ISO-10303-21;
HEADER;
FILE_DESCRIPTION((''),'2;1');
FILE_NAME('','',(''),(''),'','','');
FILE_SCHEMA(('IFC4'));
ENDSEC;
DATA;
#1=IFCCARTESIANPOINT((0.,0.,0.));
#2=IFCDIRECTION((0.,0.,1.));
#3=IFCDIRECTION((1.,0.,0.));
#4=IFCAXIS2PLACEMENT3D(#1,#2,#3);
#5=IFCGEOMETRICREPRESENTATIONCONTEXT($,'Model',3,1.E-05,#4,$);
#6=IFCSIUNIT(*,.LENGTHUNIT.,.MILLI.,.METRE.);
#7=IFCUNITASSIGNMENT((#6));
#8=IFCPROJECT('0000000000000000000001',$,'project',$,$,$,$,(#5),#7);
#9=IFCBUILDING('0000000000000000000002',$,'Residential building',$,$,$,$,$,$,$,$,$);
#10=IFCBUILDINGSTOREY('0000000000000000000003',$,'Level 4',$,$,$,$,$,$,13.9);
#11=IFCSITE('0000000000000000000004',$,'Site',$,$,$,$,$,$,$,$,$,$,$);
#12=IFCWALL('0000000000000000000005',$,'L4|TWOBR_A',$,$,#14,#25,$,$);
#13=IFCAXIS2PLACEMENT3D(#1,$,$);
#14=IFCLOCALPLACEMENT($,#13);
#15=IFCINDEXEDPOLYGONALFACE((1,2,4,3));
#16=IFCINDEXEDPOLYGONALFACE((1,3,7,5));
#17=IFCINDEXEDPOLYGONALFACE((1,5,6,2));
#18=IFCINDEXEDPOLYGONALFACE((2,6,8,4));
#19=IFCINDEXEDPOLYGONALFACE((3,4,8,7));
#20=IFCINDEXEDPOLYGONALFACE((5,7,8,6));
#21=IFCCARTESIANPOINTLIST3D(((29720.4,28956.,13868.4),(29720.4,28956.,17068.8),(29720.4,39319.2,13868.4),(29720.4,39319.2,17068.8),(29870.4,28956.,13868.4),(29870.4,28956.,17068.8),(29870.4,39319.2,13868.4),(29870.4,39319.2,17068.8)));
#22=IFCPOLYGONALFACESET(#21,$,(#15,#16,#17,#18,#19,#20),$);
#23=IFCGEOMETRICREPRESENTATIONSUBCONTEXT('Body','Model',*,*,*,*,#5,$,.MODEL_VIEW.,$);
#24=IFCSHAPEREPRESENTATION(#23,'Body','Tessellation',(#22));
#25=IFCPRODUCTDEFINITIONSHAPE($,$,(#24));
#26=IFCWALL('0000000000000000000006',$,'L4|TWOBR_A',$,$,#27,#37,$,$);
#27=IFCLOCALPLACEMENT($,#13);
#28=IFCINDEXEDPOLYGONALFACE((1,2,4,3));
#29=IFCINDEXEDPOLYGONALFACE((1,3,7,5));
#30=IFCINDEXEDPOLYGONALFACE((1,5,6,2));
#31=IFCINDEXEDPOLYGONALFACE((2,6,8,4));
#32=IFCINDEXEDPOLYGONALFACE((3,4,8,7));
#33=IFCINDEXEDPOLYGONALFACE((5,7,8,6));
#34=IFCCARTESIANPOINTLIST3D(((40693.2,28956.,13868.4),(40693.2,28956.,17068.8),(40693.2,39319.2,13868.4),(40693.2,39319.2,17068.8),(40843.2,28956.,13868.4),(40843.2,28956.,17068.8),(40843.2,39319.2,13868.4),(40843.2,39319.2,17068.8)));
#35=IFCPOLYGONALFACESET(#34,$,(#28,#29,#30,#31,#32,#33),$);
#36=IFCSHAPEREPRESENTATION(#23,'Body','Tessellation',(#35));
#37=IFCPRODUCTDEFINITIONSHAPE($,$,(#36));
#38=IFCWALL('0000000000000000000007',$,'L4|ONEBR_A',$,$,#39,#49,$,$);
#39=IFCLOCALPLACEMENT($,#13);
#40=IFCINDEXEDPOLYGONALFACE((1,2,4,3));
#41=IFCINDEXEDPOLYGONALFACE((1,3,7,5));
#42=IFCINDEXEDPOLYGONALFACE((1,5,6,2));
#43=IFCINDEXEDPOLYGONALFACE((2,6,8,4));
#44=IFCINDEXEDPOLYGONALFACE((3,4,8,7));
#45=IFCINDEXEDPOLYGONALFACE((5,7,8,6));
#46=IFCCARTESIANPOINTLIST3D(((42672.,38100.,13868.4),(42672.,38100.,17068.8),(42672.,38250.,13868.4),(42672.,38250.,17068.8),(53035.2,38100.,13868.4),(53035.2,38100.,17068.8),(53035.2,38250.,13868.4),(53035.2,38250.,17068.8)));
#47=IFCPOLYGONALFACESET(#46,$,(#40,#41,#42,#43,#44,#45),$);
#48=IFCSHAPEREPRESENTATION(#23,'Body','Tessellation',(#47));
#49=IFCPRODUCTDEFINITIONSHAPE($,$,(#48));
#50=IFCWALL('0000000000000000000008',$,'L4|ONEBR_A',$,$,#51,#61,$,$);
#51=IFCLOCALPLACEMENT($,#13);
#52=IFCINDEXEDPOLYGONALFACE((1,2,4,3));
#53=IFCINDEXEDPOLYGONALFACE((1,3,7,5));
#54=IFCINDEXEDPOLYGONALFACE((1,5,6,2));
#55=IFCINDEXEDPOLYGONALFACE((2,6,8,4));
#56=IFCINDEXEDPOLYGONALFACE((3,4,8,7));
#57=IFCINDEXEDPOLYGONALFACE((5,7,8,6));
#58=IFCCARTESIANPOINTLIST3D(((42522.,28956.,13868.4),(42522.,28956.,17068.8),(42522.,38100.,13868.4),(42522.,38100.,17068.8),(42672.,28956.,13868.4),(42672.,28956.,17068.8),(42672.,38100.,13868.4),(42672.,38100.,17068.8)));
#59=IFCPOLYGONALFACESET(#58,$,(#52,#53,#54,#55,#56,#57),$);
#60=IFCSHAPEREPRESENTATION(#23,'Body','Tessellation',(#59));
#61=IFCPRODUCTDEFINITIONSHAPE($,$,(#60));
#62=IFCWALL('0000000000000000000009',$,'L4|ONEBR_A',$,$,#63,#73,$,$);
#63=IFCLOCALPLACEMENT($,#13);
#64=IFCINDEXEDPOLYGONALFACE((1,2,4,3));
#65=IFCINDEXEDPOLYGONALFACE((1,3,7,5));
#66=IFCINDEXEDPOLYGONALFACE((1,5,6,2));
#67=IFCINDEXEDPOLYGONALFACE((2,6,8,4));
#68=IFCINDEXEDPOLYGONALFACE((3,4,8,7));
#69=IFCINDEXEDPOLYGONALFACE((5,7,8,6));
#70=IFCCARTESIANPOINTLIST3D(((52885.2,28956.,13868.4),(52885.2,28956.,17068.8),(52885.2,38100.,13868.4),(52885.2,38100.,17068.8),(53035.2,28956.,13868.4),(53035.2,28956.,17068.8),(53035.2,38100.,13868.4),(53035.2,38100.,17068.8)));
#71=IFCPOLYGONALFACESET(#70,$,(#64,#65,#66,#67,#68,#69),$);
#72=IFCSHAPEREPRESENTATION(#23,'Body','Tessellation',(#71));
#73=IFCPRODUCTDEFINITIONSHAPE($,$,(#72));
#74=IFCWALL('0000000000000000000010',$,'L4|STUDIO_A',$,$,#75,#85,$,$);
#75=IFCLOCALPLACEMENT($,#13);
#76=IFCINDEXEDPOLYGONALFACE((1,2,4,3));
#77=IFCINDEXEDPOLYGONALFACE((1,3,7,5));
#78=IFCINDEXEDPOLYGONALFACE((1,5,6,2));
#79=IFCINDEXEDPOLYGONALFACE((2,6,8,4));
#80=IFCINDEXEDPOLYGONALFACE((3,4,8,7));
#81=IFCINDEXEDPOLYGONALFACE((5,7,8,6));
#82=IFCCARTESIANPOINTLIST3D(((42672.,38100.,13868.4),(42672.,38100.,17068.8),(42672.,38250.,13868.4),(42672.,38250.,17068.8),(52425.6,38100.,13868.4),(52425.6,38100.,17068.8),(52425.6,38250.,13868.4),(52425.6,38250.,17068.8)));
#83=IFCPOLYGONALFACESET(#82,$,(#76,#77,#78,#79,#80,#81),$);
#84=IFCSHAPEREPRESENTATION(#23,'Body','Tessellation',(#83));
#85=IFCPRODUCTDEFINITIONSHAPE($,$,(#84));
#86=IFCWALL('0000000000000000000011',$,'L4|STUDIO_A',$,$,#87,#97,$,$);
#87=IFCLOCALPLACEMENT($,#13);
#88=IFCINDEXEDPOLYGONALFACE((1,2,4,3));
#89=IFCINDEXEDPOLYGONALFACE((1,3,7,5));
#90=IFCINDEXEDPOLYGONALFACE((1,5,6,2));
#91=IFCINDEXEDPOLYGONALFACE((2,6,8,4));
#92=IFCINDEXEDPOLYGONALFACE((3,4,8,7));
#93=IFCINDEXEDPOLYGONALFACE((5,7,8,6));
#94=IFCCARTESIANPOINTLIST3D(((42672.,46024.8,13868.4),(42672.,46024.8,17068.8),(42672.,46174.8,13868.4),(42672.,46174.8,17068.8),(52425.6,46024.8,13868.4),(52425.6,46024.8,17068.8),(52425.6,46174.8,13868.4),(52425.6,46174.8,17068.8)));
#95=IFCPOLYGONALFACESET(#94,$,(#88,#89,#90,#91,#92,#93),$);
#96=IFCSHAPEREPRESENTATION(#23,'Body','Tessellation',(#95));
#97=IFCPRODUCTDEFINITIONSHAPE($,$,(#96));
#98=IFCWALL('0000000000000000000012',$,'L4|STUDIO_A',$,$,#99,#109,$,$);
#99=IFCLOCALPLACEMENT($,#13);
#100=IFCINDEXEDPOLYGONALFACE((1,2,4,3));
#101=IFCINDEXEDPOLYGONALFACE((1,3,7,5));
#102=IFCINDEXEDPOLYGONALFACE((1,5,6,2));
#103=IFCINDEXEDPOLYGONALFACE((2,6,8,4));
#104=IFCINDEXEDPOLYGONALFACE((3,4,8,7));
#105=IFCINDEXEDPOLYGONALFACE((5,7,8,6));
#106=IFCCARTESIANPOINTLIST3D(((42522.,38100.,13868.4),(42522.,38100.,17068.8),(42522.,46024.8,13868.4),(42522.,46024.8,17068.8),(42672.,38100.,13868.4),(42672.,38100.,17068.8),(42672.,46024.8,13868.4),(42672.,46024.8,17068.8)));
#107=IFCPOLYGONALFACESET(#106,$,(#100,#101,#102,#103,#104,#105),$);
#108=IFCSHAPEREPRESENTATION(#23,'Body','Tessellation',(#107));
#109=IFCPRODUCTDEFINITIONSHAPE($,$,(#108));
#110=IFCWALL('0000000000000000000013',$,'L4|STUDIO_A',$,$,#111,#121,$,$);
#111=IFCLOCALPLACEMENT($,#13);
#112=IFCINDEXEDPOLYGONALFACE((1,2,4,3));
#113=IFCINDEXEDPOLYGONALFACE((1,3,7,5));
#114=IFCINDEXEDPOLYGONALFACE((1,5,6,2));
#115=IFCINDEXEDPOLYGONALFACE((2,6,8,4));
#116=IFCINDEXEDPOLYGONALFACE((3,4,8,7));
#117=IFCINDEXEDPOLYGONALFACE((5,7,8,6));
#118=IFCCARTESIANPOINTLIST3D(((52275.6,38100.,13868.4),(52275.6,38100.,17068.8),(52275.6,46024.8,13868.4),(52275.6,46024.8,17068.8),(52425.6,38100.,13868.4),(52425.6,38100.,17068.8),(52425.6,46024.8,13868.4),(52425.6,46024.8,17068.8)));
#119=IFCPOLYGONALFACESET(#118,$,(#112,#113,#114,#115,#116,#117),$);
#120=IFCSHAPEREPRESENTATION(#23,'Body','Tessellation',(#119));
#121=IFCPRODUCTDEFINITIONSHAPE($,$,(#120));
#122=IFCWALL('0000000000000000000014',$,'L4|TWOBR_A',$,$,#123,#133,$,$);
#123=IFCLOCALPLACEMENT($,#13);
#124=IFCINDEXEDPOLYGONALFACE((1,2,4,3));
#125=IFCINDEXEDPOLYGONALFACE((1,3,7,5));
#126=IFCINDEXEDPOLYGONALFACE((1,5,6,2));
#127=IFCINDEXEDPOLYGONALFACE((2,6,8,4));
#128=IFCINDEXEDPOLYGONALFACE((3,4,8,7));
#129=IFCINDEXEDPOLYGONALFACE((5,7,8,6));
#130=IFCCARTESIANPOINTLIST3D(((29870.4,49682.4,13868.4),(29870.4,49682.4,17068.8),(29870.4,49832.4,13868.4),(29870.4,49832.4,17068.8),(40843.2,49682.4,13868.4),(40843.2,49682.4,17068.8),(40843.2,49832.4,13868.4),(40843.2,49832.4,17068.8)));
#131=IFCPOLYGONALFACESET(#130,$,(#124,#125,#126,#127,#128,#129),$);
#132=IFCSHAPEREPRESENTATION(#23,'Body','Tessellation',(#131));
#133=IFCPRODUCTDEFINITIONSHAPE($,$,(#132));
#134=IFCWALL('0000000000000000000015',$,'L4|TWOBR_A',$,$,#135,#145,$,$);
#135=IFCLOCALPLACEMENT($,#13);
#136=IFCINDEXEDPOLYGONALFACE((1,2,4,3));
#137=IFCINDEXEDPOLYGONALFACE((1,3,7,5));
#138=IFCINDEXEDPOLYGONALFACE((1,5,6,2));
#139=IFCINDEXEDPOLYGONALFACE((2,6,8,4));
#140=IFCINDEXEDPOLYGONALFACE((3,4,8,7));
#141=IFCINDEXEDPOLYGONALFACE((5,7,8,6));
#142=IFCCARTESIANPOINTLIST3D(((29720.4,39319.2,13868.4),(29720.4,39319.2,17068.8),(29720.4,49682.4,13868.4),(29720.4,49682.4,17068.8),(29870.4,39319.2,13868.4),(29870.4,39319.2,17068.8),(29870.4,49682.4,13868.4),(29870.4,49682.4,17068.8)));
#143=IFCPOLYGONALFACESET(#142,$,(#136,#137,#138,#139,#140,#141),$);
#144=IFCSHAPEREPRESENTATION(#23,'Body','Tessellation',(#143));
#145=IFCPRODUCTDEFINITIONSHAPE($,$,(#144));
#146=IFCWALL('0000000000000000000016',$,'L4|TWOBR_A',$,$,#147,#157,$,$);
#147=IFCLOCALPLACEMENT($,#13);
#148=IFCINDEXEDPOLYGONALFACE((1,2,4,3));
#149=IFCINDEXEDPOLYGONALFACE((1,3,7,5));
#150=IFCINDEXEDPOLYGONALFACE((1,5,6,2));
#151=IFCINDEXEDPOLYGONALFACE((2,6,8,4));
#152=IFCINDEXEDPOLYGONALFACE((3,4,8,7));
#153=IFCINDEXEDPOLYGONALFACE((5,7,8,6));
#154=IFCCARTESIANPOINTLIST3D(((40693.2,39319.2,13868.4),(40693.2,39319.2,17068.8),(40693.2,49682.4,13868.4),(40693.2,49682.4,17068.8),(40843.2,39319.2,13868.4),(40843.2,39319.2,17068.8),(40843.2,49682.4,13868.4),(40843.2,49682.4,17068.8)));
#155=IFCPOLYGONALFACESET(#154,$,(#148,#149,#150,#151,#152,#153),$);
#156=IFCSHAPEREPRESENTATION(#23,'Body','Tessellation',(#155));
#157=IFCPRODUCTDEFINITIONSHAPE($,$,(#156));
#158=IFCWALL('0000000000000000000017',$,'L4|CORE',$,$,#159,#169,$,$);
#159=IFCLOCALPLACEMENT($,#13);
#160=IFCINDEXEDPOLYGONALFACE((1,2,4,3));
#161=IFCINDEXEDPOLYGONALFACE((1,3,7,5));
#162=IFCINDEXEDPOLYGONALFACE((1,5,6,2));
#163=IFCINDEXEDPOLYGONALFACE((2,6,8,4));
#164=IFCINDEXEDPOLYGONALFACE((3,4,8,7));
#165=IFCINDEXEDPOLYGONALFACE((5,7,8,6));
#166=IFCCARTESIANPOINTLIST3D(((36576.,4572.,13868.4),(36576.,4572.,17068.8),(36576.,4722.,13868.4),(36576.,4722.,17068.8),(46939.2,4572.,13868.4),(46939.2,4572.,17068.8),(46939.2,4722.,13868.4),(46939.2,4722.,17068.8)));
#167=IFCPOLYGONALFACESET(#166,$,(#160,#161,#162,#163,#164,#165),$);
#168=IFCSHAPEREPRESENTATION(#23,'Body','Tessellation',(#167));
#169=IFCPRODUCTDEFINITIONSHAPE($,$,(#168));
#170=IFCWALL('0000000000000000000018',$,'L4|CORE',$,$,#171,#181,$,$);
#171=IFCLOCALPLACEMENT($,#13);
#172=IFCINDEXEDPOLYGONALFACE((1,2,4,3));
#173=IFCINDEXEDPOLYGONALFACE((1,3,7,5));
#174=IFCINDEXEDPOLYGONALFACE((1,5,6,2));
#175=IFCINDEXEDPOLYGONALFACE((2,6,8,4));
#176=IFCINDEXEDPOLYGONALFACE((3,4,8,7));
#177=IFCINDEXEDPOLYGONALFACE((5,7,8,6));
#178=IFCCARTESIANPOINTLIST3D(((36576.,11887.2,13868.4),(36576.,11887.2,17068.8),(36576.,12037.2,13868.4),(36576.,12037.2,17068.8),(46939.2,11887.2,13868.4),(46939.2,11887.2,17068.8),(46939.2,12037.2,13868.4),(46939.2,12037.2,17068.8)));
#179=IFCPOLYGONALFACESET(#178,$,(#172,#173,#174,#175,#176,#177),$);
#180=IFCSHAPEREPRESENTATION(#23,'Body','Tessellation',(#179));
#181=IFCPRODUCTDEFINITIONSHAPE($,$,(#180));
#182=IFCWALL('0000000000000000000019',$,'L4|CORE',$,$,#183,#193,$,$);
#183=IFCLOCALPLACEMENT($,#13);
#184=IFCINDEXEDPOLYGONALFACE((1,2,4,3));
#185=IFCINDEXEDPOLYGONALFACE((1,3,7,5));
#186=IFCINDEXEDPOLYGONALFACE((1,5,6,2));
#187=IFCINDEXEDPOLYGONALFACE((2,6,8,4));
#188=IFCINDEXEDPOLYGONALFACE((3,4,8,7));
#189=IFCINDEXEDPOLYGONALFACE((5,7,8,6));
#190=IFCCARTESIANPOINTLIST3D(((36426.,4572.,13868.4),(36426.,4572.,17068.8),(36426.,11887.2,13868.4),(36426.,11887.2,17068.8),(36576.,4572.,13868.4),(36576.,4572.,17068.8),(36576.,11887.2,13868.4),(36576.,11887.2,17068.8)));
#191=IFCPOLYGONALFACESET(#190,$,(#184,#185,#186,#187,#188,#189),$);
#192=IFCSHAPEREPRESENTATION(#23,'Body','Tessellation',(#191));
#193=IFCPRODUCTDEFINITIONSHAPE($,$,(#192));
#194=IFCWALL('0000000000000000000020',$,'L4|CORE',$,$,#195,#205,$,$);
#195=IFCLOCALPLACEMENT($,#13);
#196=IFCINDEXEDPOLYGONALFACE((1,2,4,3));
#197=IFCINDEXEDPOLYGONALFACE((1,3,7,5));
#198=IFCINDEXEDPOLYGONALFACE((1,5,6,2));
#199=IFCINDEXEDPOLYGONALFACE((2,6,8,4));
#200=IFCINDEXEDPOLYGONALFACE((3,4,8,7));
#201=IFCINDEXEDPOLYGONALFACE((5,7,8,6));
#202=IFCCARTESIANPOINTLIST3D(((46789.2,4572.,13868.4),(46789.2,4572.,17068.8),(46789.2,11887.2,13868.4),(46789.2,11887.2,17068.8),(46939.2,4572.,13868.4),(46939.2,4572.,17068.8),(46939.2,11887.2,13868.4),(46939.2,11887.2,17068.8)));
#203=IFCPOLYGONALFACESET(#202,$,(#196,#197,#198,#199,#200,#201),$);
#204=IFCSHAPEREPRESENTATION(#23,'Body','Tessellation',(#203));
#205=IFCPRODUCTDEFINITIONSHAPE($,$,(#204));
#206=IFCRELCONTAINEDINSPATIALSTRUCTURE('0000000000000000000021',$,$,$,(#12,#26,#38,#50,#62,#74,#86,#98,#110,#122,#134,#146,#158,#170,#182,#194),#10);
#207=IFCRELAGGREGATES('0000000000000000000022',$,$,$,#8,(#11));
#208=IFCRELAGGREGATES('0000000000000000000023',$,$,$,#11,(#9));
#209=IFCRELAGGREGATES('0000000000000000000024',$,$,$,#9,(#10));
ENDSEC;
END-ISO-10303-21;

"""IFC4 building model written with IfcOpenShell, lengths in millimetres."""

from ifc_helpers import new_model, si_unit, frame, origin_with_axes, place, context, subcontext, project, spatial, indexed_curve, outline, extrude, element, save


model = new_model("IFC4")

# Units and contexts
model_context = context("Model", 3, precision=1e-05, world=origin_with_axes())
body_context = subcontext(model_context, "Body", "Model", "MODEL_VIEW")
ifc_project = project(units=[si_unit("LENGTHUNIT", "METRE", prefix="MILLI")], contexts=[model_context])

# Site, building, storey
site = spatial("IfcSite", under=ifc_project, Name="Site")
building = spatial("IfcBuilding", under=site, Name="Residential building")
storey = spatial("IfcBuildingStorey", under=building, Name="Level 4", Elevation=13.9)

# Walls
for number, where, z_axis, x_axis, name in (
    (1, (29870.4, 28956.0, 13868.4), (0.0, 0.0, 1.0), (0.0, 1.0, 0.0), "L4|TWOBR_A"),
    (2, (40843.2, 28956.0, 13868.4), (0.0, 0.0, 1.0), (0.0, 1.0, 0.0), "L4|TWOBR_A"),
    (3, (42672.0, 38100.0, 13868.4), (0.0, 0.0, 1.0), (1.0, 0.0, 0.0), "L4|ONEBR_A"),
):
    element("IfcWall", number, at=place(None, frame(where, z_axis=z_axis, x_axis=x_axis)), inside=storey, Name=name, context=body_context, shape_type="SweptSolid", body=[
        extrude(outline(indexed_curve([(0.0, 0.0), (0.0, 150.0), (10363.2, 150.0), (10363.2, 0.0), (0.0, 0.0)], self_intersect=False)), origin_with_axes(), (0.0, 0.0, 1.0), 3200.4),
    ])
for number, where, z_axis, x_axis, name in (
    (4, (42672.0, 28956.0, 13868.4), (0.0, 0.0, 1.0), (0.0, 1.0, 0.0), "L4|ONEBR_A"),
    (5, (53035.2, 28956.0, 13868.4), (0.0, 0.0, 1.0), (0.0, 1.0, 0.0), "L4|ONEBR_A"),
):
    element("IfcWall", number, at=place(None, frame(where, z_axis=z_axis, x_axis=x_axis)), inside=storey, Name=name, context=body_context, shape_type="SweptSolid", body=[
        extrude(outline(indexed_curve([(0.0, 0.0), (0.0, 150.0), (9144.0, 150.0), (9144.0, 0.0), (0.0, 0.0)], self_intersect=False)), origin_with_axes(), (0.0, 0.0, 1.0), 3200.4),
    ])
for number, where, z_axis, x_axis, name in (
    (6, (42672.0, 38100.0, 13868.4), (0.0, 0.0, 1.0), (1.0, 0.0, 0.0), "L4|STUDIO_A"),
    (7, (42672.0, 46024.8, 13868.4), (0.0, 0.0, 1.0), (1.0, 0.0, 0.0), "L4|STUDIO_A"),
):
    element("IfcWall", number, at=place(None, frame(where, z_axis=z_axis, x_axis=x_axis)), inside=storey, Name=name, context=body_context, shape_type="SweptSolid", body=[
        extrude(outline(indexed_curve([(0.0, 0.0), (0.0, 150.0), (9753.6, 150.0), (9753.6, 0.0), (0.0, 0.0)], self_intersect=False)), origin_with_axes(), (0.0, 0.0, 1.0), 3200.4),
    ])
for number, where, z_axis, x_axis, name in (
    (8, (42672.0, 38100.0, 13868.4), (0.0, 0.0, 1.0), (0.0, 1.0, 0.0), "L4|STUDIO_A"),
    (9, (52425.6, 38100.0, 13868.4), (0.0, 0.0, 1.0), (0.0, 1.0, 0.0), "L4|STUDIO_A"),
):
    element("IfcWall", number, at=place(None, frame(where, z_axis=z_axis, x_axis=x_axis)), inside=storey, Name=name, context=body_context, shape_type="SweptSolid", body=[
        extrude(outline(indexed_curve([(0.0, 0.0), (0.0, 150.0), (7924.8, 150.0), (7924.8, 0.0), (0.0, 0.0)], self_intersect=False)), origin_with_axes(), (0.0, 0.0, 1.0), 3200.4),
    ])
for number, where, z_axis, x_axis, name in (
    (10, (29870.4, 49682.4, 13868.4), (0.0, 0.0, 1.0), (1.0, 0.0, 0.0), "L4|TWOBR_A"),
):
    element("IfcWall", number, at=place(None, frame(where, z_axis=z_axis, x_axis=x_axis)), inside=storey, Name=name, context=body_context, shape_type="SweptSolid", body=[
        extrude(outline(indexed_curve([(0.0, 0.0), (0.0, 150.0), (10972.8, 150.0), (10972.8, 0.0), (0.0, 0.0)], self_intersect=False)), origin_with_axes(), (0.0, 0.0, 1.0), 3200.4),
    ])
for number, where, z_axis, x_axis, name in (
    (11, (29870.4, 39319.2, 13868.4), (0.0, 0.0, 1.0), (0.0, 1.0, 0.0), "L4|TWOBR_A"),
    (12, (40843.2, 39319.2, 13868.4), (0.0, 0.0, 1.0), (0.0, 1.0, 0.0), "L4|TWOBR_A"),
    (13, (36576.0, 4572.0, 13868.4), (0.0, 0.0, 1.0), (1.0, 0.0, 0.0), "L4|CORE"),
    (14, (36576.0, 11887.2, 13868.4), (0.0, 0.0, 1.0), (1.0, 0.0, 0.0), "L4|CORE"),
):
    element("IfcWall", number, at=place(None, frame(where, z_axis=z_axis, x_axis=x_axis)), inside=storey, Name=name, context=body_context, shape_type="SweptSolid", body=[
        extrude(outline(indexed_curve([(0.0, 0.0), (0.0, 150.0), (10363.2, 150.0), (10363.2, 0.0), (0.0, 0.0)], self_intersect=False)), origin_with_axes(), (0.0, 0.0, 1.0), 3200.4),
    ])
for number, where, z_axis, x_axis, name in (
    (15, (36576.0, 4572.0, 13868.4), (0.0, 0.0, 1.0), (0.0, 1.0, 0.0), "L4|CORE"),
    (16, (46939.2, 4572.0, 13868.4), (0.0, 0.0, 1.0), (0.0, 1.0, 0.0), "L4|CORE"),
):
    element("IfcWall", number, at=place(None, frame(where, z_axis=z_axis, x_axis=x_axis)), inside=storey, Name=name, context=body_context, shape_type="SweptSolid", body=[
        extrude(outline(indexed_curve([(0.0, 0.0), (0.0, 150.0), (7315.2, 150.0), (7315.2, 0.0), (0.0, 0.0)], self_intersect=False)), origin_with_axes(), (0.0, 0.0, 1.0), 3200.4),
    ])

save(model, "model.ifc")
